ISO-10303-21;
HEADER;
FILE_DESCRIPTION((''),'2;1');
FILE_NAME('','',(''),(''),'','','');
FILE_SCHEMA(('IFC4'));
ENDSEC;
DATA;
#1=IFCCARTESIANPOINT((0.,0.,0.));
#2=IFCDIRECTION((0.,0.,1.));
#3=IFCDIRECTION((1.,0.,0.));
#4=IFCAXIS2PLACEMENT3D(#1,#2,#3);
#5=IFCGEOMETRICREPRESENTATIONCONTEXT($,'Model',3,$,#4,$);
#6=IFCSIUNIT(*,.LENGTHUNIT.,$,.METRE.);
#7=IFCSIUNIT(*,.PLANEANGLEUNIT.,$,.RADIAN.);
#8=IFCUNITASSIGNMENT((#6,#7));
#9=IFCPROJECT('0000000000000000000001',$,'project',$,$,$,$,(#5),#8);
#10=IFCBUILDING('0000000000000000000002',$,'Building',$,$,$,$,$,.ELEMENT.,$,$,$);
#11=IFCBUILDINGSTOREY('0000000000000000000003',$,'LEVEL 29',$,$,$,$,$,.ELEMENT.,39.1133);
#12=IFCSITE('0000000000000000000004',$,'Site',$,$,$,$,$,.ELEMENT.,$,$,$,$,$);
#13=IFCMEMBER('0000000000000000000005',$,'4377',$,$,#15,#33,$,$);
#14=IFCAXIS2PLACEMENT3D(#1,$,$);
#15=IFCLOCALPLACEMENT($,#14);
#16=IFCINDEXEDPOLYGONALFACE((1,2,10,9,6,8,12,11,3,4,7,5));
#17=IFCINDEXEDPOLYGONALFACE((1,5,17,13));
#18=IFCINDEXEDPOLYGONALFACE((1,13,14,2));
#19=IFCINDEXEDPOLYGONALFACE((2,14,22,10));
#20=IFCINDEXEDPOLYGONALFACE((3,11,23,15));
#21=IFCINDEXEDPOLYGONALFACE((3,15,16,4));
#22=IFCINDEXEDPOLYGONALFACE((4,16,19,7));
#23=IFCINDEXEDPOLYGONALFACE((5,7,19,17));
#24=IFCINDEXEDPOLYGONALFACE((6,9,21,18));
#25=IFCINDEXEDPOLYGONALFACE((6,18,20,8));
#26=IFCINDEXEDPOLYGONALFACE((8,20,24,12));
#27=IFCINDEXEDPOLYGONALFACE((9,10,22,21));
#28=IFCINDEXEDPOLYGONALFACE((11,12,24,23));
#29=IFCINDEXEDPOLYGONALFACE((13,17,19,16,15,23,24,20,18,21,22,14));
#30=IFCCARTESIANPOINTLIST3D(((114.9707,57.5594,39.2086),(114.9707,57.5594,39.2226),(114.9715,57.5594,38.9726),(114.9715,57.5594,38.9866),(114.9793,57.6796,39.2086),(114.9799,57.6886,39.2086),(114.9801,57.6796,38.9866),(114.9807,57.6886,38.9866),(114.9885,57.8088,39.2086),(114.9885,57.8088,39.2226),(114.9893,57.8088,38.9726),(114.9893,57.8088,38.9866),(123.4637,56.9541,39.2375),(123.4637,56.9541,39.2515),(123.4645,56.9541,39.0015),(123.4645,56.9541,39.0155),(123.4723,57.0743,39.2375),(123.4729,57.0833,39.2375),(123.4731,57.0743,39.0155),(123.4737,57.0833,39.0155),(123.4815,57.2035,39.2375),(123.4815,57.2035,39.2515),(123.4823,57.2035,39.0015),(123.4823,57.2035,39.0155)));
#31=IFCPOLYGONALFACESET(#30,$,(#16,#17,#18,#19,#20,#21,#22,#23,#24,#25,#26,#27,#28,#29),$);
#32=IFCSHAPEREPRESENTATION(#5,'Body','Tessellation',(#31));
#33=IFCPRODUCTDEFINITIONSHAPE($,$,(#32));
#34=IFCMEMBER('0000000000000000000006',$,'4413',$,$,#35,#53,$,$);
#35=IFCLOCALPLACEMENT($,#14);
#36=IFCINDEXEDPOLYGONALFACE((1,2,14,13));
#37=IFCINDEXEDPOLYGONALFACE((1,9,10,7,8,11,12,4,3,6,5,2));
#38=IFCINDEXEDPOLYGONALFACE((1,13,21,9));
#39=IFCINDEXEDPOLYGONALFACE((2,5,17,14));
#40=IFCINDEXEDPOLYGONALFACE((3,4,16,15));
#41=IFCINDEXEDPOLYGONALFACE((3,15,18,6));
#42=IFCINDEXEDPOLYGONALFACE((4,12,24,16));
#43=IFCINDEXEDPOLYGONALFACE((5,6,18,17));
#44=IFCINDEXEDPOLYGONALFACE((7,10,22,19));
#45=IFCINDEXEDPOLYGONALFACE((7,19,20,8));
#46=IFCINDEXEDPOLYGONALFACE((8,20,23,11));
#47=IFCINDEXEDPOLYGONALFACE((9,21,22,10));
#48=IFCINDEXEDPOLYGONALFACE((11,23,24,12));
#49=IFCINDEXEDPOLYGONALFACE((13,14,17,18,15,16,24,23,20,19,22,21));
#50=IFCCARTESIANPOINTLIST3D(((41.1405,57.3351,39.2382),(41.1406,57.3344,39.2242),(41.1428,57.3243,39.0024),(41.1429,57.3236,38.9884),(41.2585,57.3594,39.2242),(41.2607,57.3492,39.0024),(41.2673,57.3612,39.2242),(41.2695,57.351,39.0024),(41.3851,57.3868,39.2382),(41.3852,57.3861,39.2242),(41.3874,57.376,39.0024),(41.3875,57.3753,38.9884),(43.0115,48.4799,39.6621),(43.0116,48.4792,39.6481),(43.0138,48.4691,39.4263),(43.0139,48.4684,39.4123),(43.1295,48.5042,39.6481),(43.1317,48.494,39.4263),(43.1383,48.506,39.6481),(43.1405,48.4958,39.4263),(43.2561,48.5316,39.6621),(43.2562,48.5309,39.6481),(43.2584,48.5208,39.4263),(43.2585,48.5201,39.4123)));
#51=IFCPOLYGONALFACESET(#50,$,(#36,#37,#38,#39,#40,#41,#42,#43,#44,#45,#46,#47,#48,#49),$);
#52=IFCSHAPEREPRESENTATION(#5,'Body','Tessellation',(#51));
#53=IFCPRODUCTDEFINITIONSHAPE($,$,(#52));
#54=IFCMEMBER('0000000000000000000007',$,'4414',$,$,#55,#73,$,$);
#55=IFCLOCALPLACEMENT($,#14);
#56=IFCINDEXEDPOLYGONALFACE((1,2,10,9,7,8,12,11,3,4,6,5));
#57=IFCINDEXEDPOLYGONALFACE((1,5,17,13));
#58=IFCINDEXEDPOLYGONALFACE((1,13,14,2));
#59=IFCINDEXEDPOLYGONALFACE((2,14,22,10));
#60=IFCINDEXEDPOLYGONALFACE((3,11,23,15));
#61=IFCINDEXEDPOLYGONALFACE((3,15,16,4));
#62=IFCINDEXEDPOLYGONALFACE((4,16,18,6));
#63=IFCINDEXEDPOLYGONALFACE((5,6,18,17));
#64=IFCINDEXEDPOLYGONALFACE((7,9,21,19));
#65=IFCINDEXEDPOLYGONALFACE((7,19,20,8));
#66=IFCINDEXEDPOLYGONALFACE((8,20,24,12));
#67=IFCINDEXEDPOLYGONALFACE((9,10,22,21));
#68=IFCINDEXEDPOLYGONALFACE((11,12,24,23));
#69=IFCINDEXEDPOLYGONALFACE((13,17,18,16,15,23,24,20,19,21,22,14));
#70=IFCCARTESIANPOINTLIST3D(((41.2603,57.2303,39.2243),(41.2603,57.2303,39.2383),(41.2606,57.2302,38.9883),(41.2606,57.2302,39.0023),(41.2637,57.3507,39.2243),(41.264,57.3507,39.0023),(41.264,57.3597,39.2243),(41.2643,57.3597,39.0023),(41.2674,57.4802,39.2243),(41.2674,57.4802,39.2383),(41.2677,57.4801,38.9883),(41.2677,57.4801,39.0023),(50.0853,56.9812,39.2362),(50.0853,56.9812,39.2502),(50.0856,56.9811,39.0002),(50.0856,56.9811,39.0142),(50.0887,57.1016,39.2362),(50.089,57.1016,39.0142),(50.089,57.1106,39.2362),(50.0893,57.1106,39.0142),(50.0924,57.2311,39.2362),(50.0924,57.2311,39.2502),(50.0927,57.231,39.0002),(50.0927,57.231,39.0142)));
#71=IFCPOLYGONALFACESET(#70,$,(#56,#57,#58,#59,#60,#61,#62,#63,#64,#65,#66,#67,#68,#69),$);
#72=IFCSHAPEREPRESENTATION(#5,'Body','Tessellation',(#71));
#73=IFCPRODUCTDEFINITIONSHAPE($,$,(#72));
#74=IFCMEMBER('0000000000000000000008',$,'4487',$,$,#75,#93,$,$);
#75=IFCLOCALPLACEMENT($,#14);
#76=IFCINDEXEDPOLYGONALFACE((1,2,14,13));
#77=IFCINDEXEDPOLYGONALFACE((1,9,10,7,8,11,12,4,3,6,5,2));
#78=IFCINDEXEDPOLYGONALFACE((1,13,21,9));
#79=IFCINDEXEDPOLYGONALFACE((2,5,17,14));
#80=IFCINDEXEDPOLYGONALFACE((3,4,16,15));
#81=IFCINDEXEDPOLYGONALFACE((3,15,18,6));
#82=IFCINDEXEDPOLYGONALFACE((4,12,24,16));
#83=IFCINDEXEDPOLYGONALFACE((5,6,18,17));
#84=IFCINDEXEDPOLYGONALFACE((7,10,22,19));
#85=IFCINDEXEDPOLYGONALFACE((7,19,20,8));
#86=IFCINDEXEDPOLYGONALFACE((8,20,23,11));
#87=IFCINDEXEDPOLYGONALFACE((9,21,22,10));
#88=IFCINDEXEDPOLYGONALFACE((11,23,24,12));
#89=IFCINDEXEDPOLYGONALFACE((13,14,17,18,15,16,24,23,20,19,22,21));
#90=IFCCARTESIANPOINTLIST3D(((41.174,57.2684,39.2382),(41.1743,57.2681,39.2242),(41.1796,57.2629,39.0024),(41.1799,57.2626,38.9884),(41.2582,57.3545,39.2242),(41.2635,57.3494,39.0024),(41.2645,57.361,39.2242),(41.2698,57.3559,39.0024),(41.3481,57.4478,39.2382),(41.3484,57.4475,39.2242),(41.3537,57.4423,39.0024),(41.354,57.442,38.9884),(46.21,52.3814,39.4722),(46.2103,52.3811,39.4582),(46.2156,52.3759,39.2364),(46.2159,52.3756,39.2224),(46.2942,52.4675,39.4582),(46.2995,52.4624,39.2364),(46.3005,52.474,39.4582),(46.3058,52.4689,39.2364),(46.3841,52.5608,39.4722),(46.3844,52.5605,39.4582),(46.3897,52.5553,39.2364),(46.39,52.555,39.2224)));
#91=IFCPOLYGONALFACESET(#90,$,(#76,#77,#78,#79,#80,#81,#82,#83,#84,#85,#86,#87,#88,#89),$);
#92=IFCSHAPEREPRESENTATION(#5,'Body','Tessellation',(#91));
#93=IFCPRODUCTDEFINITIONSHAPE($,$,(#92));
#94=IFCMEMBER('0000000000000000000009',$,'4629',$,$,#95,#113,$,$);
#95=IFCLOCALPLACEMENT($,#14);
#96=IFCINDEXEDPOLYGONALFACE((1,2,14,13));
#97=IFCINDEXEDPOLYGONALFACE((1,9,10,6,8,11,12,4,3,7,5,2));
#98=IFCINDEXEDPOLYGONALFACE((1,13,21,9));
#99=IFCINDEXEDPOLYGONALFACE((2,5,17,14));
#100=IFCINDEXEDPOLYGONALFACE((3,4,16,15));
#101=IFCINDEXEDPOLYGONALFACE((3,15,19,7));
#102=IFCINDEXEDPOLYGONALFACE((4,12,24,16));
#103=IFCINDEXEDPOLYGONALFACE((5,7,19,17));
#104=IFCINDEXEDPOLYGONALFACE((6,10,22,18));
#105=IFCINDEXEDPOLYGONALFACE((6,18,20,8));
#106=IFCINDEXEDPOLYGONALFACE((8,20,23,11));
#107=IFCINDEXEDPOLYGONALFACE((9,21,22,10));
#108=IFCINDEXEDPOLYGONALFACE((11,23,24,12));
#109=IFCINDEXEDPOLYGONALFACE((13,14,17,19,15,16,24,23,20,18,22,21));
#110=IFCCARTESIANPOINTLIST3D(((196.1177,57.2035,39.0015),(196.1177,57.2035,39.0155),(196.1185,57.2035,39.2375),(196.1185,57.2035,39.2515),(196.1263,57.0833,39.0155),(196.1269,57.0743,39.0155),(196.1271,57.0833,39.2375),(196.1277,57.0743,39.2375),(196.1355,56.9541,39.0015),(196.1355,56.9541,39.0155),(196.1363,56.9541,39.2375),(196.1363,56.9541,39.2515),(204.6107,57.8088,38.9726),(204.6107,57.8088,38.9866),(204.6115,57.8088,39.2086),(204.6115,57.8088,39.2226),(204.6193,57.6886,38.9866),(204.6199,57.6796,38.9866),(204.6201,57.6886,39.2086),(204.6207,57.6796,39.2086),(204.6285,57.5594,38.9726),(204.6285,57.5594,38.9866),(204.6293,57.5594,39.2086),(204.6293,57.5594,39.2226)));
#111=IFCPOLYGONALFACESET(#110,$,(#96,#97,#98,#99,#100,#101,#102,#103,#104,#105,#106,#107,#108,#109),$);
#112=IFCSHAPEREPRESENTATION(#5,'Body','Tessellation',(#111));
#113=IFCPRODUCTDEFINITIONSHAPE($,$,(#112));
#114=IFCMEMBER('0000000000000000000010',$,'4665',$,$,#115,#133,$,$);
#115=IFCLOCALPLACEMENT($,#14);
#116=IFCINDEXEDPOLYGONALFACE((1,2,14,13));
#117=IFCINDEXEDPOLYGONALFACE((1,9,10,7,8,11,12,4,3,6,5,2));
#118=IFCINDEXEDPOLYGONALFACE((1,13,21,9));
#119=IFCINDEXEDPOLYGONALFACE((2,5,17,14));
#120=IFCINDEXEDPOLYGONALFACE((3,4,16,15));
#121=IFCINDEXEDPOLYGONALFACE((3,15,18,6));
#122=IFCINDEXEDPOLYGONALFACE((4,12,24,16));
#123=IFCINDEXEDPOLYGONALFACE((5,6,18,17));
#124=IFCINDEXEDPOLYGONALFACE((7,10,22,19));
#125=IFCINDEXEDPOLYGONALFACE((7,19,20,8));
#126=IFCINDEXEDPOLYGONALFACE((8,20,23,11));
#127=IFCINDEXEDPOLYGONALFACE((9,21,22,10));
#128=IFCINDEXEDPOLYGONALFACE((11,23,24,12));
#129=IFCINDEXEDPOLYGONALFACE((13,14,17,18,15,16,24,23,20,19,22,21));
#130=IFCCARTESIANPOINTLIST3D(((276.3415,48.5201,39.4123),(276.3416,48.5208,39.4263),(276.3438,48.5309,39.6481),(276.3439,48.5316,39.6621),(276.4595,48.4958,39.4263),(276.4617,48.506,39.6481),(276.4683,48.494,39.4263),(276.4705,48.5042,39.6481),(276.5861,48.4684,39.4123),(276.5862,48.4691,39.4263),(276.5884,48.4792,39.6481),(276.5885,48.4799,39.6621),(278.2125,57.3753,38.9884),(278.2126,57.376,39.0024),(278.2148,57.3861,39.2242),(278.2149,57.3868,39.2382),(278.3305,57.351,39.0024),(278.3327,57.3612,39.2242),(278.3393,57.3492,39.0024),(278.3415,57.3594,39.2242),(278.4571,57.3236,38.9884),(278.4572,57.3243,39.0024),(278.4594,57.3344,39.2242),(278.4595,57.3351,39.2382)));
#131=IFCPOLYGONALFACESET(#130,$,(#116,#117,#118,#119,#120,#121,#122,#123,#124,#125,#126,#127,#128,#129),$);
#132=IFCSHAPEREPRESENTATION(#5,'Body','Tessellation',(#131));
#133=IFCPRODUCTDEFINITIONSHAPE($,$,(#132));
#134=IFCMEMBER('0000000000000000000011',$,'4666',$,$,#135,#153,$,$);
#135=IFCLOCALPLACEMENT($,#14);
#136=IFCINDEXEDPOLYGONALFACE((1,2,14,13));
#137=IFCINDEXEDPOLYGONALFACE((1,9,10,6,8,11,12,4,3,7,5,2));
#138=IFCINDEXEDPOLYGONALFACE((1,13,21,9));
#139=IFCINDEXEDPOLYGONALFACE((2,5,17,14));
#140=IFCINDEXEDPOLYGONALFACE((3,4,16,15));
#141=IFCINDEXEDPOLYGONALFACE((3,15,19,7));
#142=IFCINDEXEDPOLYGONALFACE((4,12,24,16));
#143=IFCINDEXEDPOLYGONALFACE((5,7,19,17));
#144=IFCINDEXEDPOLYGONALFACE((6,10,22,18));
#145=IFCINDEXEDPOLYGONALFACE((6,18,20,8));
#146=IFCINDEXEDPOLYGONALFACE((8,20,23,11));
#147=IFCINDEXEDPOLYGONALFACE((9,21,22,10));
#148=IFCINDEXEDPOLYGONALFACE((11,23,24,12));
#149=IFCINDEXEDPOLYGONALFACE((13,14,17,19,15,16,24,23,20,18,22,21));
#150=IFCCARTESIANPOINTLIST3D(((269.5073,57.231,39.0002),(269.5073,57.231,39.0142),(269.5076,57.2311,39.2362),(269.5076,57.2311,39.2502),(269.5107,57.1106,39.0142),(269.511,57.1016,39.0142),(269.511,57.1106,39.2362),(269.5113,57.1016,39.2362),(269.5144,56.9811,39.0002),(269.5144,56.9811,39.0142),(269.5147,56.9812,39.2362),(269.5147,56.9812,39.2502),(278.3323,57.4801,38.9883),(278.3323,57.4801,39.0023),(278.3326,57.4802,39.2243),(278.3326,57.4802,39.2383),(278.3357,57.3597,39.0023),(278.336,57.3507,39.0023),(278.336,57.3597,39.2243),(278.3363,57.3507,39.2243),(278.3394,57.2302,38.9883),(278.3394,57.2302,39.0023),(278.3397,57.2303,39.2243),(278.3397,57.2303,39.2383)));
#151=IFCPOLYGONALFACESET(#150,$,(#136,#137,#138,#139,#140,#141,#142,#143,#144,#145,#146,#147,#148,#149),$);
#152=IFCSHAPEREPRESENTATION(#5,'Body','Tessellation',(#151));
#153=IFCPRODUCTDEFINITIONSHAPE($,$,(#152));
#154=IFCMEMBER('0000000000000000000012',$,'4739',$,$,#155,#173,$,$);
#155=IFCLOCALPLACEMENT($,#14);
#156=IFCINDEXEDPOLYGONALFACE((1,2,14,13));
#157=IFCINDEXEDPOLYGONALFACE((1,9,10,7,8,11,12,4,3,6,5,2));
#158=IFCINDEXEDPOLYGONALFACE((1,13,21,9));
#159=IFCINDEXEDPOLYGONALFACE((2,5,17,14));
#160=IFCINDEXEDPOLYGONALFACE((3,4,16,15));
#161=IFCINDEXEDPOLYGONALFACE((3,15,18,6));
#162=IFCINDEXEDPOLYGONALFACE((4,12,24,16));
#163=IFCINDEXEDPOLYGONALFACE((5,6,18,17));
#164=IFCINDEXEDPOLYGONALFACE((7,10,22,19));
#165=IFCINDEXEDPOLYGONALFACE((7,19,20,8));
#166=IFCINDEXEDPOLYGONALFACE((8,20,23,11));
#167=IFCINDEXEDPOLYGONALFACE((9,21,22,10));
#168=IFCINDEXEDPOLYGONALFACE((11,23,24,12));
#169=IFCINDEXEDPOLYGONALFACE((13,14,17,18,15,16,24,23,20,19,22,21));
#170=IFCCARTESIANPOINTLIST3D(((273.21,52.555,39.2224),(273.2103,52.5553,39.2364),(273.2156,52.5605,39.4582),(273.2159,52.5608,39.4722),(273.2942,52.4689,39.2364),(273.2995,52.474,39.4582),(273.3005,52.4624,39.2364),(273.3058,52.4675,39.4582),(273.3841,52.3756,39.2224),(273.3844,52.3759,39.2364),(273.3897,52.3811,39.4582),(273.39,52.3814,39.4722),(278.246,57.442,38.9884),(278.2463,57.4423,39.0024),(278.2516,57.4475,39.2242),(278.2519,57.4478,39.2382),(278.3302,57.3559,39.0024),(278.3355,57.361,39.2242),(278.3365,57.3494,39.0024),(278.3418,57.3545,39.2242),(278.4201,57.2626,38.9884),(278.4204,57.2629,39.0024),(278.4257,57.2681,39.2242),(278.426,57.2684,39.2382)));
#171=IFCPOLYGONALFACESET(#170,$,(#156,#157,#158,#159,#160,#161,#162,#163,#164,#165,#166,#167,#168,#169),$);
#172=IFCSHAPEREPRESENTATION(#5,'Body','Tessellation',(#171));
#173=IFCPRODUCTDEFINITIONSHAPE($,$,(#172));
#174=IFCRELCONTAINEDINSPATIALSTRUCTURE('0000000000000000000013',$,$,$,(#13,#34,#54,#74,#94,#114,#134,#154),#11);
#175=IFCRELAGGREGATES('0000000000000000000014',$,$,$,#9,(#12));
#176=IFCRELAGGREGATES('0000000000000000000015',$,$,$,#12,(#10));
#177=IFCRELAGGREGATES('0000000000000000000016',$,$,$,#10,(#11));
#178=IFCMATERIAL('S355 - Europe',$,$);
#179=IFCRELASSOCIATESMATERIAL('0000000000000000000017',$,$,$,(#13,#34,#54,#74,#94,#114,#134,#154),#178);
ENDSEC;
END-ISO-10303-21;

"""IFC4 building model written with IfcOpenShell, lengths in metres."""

from ifc_helpers import new_model, si_unit, frame, origin_with_axes, origin_2d_with_axis, place, context, project, spatial, i_section, extrude, material, material_profile, profile_set, profile_usage, element, save


model = new_model("IFC4")

# Units and contexts
model_context = context("Model", 3, world=origin_with_axes())
ifc_project = project(units=[si_unit("LENGTHUNIT", "METRE"), si_unit("PLANEANGLEUNIT", "RADIAN")], contexts=[model_context])

# Site, building, storey
site = spatial("IfcSite", under=ifc_project, Name="Site", CompositionType="ELEMENT")
building = spatial("IfcBuilding", under=site, Name="Building", CompositionType="ELEMENT")
storey = spatial("IfcBuildingStorey", under=building, Name="LEVEL 29", CompositionType="ELEMENT", Elevation=39.1133)

# Members
ifc_material = material(Name="S355 - Europe")
ifc_material_profile_1 = material_profile(ifc_material, i_section(OverallWidth=0.25, OverallDepth=0.25, WebThickness=0.009, FlangeThickness=0.014, at=origin_2d_with_axis()))
ifc_profile_set_1 = profile_set([ifc_material_profile_1])
ifc_profile_usage_1 = profile_usage(ifc_profile_set_1, cardinal=10)
member_1_placement = place(None, frame((123.473, 57.0788, 39.1265), z_axis=(-0.997464, 0.07109, -0.003394), x_axis=(-0.07109, -0.99747, 0.0)))
element("IfcMember", 1, at=member_1_placement, inside=storey, material=ifc_profile_usage_1, Name="4377", context=model_context, shape_type="SweptSolid", body=[
    extrude(i_section(OverallWidth=0.25, OverallDepth=0.25, WebThickness=0.009, FlangeThickness=0.014, at=origin_2d_with_axis()), origin_with_axes(), (0.0, 0.0, 1.0), 8.5146),
])
ifc_material_profile_2 = material_profile(ifc_material, i_section(OverallWidth=0.25, OverallDepth=0.25, WebThickness=0.009, FlangeThickness=0.014, at=origin_2d_with_axis()))
ifc_profile_set_2 = profile_set([ifc_material_profile_2])
ifc_profile_usage_2 = profile_usage(ifc_profile_set_2, cardinal=10)
member_2_placement = place(None, frame((43.135, 48.5, 39.5372), z_axis=(-0.206498, 0.977328, -0.046785), x_axis=(-0.978399, -0.206724, 0.0)))
element("IfcMember", 2, at=member_2_placement, inside=storey, material=ifc_profile_usage_2, Name="4413", context=model_context, shape_type="SweptSolid", body=[
    extrude(i_section(OverallWidth=0.25, OverallDepth=0.25, WebThickness=0.009, FlangeThickness=0.014, at=origin_2d_with_axis()), origin_with_axes(), (0.0, 0.0, 1.0), 9.0606),
])
ifc_material_profile_3 = material_profile(ifc_material, i_section(OverallWidth=0.25, OverallDepth=0.25, WebThickness=0.009, FlangeThickness=0.014, at=origin_2d_with_axis()))
ifc_profile_set_3 = profile_set([ifc_material_profile_3])
ifc_profile_usage_3 = profile_usage(ifc_profile_set_3, cardinal=10)
member_3_placement = place(None, frame((50.089, 57.1061, 39.1252), z_axis=(-0.999601, 0.028215, -0.001348), x_axis=(-0.028215, -0.999602, 0.0)))
element("IfcMember", 3, at=member_3_placement, inside=storey, material=ifc_profile_usage_3, Name="4414", context=model_context, shape_type="SweptSolid", body=[
    extrude(i_section(OverallWidth=0.25, OverallDepth=0.25, WebThickness=0.009, FlangeThickness=0.014, at=origin_2d_with_axis()), origin_with_axes(), (0.0, 0.0, 1.0), 8.8285),
])
ifc_material_profile_4 = material_profile(ifc_material, i_section(OverallWidth=0.25, OverallDepth=0.25, WebThickness=0.009, FlangeThickness=0.014, at=origin_2d_with_axis()))
ifc_profile_set_4 = profile_set([ifc_material_profile_4])
ifc_profile_usage_4 = profile_usage(ifc_profile_set_4, cardinal=10)
member_4_placement = place(None, frame((46.3, 52.4682, 39.3473), z_axis=(-0.717245, 0.696024, -0.033327), x_axis=(-0.695514, -0.718512, 0.0)))
element("IfcMember", 4, at=member_4_placement, inside=storey, material=ifc_profile_usage_4, Name="4487", context=model_context, shape_type="SweptSolid", body=[
    extrude(i_section(OverallWidth=0.25, OverallDepth=0.25, WebThickness=0.009, FlangeThickness=0.014, at=origin_2d_with_axis()), origin_with_axes(), (0.0, 0.0, 1.0), 7.0213),
])
ifc_material_profile_5 = material_profile(ifc_material, i_section(OverallWidth=0.25, OverallDepth=0.25, WebThickness=0.009, FlangeThickness=0.014, at=origin_2d_with_axis()))
ifc_profile_set_5 = profile_set([ifc_material_profile_5])
ifc_profile_usage_5 = profile_usage(ifc_profile_set_5, cardinal=10)
member_5_placement = place(None, frame((196.127, 57.0788, 39.1265), z_axis=(0.997464, 0.07109, -0.003394), x_axis=(-0.07109, 0.99747, 0.0)))
element("IfcMember", 5, at=member_5_placement, inside=storey, material=ifc_profile_usage_5, Name="4629", context=model_context, shape_type="SweptSolid", body=[
    extrude(i_section(OverallWidth=0.25, OverallDepth=0.25, WebThickness=0.009, FlangeThickness=0.014, at=origin_2d_with_axis()), origin_with_axes(), (0.0, 0.0, 1.0), 8.5146),
])
ifc_material_profile_6 = material_profile(ifc_material, i_section(OverallWidth=0.25, OverallDepth=0.25, WebThickness=0.009, FlangeThickness=0.014, at=origin_2d_with_axis()))
ifc_profile_set_6 = profile_set([ifc_material_profile_6])
ifc_profile_usage_6 = profile_usage(ifc_profile_set_6, cardinal=10)
member_6_placement = place(None, frame((276.465, 48.5, 39.5372), z_axis=(0.206498, 0.977328, -0.046785), x_axis=(-0.978399, 0.206724, 0.0)))
element("IfcMember", 6, at=member_6_placement, inside=storey, material=ifc_profile_usage_6, Name="4665", context=model_context, shape_type="SweptSolid", body=[
    extrude(i_section(OverallWidth=0.25, OverallDepth=0.25, WebThickness=0.009, FlangeThickness=0.014, at=origin_2d_with_axis()), origin_with_axes(), (0.0, 0.0, 1.0), 9.0606),
])
ifc_material_profile_7 = material_profile(ifc_material, i_section(OverallWidth=0.25, OverallDepth=0.25, WebThickness=0.009, FlangeThickness=0.014, at=origin_2d_with_axis()))
ifc_profile_set_7 = profile_set([ifc_material_profile_7])
ifc_profile_usage_7 = profile_usage(ifc_profile_set_7, cardinal=10)
member_7_placement = place(None, frame((269.511, 57.1061, 39.1252), z_axis=(0.999601, 0.028215, -0.001348), x_axis=(-0.028215, 0.999602, 0.0)))
element("IfcMember", 7, at=member_7_placement, inside=storey, material=ifc_profile_usage_7, Name="4666", context=model_context, shape_type="SweptSolid", body=[
    extrude(i_section(OverallWidth=0.25, OverallDepth=0.25, WebThickness=0.009, FlangeThickness=0.014, at=origin_2d_with_axis()), origin_with_axes(), (0.0, 0.0, 1.0), 8.8285),
])
ifc_material_profile_8 = material_profile(ifc_material, i_section(OverallWidth=0.25, OverallDepth=0.25, WebThickness=0.009, FlangeThickness=0.014, at=origin_2d_with_axis()))
ifc_profile_set_8 = profile_set([ifc_material_profile_8])
ifc_profile_usage_8 = profile_usage(ifc_profile_set_8, cardinal=10)
member_8_placement = place(None, frame((273.3, 52.4682, 39.3473), z_axis=(0.717245, 0.696024, -0.033327), x_axis=(-0.695544, 0.718483, 0.0)))
element("IfcMember", 8, at=member_8_placement, inside=storey, material=ifc_profile_usage_8, Name="4739", context=model_context, shape_type="SweptSolid", body=[
    extrude(i_section(OverallWidth=0.25, OverallDepth=0.25, WebThickness=0.009, FlangeThickness=0.014, at=origin_2d_with_axis()), origin_with_axes(), (0.0, 0.0, 1.0), 7.0213),
])

save(model, "model.ifc")
